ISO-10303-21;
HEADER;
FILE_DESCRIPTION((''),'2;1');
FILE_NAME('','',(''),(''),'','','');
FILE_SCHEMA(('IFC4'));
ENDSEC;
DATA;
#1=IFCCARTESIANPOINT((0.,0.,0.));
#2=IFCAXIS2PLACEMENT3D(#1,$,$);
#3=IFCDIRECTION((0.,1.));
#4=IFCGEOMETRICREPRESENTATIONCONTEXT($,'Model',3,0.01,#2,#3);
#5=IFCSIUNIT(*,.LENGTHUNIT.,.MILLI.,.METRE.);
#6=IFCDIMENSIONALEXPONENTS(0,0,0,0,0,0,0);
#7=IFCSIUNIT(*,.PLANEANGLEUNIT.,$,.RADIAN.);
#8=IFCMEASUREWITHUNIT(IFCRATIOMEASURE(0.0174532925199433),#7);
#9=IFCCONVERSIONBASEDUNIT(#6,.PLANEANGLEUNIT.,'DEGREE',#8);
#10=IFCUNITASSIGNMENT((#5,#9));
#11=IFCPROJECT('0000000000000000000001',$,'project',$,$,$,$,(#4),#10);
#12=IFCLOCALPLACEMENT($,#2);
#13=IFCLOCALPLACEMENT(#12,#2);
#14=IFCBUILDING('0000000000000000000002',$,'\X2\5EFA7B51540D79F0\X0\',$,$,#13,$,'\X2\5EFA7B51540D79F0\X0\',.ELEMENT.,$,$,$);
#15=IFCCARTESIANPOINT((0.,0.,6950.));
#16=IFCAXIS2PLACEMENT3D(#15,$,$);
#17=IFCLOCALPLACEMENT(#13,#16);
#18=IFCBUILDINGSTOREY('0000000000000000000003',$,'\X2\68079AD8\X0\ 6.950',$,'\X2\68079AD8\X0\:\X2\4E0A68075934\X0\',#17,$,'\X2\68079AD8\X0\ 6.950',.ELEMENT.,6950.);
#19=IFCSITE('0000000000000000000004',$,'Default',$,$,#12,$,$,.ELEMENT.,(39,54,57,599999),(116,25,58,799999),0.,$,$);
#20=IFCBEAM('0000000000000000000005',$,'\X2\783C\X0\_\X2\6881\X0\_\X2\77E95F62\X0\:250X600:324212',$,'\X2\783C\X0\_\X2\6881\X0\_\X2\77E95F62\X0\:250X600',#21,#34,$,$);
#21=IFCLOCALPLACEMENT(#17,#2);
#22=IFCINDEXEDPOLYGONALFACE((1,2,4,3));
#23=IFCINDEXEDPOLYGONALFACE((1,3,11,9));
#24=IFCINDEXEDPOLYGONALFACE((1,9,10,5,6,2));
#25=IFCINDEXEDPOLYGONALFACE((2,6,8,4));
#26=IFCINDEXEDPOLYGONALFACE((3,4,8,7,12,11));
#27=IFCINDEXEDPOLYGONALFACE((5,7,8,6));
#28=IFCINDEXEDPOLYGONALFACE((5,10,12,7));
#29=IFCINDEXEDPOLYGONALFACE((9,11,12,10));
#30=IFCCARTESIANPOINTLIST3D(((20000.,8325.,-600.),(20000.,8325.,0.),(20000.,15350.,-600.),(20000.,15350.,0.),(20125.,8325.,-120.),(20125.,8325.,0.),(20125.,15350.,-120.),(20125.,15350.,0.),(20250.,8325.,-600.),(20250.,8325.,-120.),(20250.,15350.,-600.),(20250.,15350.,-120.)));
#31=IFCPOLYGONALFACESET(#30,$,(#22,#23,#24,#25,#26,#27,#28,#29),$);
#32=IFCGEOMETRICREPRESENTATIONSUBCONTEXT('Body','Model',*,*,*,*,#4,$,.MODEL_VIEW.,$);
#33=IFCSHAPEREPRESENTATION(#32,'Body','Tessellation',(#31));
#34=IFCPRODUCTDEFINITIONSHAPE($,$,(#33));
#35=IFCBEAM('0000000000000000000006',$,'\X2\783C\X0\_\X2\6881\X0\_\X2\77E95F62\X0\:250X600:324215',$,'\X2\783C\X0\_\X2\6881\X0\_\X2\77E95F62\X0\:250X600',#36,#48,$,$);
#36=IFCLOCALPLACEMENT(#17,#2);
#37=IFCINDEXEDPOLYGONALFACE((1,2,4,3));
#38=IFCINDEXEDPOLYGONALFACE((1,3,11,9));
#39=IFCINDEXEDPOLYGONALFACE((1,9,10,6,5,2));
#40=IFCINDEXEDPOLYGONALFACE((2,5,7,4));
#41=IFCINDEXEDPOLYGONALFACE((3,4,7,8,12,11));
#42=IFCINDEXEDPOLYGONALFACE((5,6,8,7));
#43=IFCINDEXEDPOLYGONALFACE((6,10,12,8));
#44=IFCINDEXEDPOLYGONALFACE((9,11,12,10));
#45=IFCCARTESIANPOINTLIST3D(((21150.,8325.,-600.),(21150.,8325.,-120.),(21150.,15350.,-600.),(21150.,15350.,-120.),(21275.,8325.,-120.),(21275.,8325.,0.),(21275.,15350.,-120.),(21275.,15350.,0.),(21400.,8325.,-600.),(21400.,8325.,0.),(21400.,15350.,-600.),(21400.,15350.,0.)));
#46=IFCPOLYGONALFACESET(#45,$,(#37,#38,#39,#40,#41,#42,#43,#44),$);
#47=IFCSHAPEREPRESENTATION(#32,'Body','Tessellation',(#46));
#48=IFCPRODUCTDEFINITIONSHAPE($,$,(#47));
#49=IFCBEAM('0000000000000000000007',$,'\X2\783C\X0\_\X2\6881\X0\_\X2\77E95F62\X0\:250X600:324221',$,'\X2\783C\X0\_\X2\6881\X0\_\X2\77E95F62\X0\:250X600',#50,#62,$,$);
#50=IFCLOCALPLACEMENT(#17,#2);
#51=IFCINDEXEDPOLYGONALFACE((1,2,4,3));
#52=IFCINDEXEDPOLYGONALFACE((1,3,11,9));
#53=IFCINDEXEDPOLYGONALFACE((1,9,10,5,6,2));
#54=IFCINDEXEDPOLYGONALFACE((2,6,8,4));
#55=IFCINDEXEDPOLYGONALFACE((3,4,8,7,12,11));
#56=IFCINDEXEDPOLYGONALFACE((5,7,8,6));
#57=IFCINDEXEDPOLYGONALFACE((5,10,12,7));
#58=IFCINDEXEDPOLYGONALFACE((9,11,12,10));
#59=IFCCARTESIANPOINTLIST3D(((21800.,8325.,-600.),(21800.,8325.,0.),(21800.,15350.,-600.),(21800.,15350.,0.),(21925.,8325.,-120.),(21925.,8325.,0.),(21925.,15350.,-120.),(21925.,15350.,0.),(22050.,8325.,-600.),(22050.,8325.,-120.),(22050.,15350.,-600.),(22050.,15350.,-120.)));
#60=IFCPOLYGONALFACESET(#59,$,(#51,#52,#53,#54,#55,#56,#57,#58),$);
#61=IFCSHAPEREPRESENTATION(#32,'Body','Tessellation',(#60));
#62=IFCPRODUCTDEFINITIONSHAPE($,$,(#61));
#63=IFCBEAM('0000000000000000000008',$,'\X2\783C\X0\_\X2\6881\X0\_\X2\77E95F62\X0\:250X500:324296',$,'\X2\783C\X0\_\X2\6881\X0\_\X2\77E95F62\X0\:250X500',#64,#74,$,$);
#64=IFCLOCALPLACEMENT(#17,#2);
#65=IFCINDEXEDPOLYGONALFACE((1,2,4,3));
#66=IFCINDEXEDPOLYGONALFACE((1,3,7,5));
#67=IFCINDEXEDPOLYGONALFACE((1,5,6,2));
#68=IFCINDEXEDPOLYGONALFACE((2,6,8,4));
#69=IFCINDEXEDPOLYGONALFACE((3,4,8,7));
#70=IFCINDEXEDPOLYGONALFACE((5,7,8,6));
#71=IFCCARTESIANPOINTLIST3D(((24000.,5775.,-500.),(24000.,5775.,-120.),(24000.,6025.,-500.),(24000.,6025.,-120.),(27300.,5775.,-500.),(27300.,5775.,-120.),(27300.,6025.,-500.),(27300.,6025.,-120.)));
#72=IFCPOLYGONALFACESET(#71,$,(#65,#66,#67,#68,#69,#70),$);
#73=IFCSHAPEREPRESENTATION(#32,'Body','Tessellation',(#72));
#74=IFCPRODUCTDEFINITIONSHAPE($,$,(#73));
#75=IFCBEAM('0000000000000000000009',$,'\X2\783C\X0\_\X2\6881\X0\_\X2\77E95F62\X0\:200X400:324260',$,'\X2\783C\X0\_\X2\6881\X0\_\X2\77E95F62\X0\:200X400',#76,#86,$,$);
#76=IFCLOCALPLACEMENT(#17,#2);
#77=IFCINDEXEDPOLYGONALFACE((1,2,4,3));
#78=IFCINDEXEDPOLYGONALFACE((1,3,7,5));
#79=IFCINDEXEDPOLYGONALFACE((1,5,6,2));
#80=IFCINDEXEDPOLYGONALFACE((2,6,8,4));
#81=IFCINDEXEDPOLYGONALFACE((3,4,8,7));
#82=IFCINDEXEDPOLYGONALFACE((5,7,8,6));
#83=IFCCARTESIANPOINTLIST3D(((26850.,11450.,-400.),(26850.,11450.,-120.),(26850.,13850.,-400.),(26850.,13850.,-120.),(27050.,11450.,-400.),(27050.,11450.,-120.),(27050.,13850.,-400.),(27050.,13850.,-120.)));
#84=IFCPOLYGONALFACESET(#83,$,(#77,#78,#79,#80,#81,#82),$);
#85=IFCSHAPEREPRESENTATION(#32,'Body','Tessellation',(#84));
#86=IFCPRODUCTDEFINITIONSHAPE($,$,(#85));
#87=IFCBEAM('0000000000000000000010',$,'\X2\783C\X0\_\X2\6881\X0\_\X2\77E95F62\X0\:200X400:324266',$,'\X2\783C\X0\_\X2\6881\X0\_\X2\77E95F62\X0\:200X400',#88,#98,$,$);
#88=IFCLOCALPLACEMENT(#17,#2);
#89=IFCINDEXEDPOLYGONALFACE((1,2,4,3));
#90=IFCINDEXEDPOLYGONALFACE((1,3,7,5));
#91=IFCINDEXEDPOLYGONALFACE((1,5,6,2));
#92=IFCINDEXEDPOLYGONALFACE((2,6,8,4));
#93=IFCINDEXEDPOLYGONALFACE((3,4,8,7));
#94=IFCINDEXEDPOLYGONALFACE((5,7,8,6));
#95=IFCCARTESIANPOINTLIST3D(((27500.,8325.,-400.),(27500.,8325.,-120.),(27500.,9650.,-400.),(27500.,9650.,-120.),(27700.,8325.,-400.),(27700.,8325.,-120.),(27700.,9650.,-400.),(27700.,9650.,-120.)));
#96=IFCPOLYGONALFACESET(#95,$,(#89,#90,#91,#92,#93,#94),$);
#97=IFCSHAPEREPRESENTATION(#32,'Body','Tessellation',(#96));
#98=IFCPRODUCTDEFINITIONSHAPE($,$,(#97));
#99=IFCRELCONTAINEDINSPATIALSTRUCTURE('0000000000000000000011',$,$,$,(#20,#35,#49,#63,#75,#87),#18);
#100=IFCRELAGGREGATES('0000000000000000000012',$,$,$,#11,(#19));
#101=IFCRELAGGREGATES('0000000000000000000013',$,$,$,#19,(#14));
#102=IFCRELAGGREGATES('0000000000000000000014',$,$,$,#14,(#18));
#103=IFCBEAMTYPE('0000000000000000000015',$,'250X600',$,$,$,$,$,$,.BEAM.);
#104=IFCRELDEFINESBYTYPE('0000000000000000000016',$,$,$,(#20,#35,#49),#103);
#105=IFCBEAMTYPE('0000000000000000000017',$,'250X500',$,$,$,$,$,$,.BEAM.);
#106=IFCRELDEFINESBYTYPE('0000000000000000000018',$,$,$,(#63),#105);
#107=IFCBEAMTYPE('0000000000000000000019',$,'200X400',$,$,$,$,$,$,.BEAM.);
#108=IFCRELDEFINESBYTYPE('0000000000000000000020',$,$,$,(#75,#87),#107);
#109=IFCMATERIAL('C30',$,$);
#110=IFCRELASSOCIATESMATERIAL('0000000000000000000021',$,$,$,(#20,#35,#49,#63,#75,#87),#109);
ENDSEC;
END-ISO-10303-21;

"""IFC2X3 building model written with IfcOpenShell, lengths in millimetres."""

from ifc_helpers import new_model, entity, si_unit, converted_unit, direction, frame, frame_2d, origin, place, context, subcontext, project, spatial, polyline, rectangle, outline, extrude, material, type_object, element, save


model = new_model("IFC2X3")

# Units and contexts
model_context = context("Model", 3, precision=0.01, world=origin(), true_north=direction((0.0, 1.0)))
body_context = subcontext(model_context, "Body", "Model", "MODEL_VIEW")
ifc_project = project(units=[si_unit("LENGTHUNIT", "METRE", prefix="MILLI"), converted_unit("PLANEANGLEUNIT", "DEGREE", entity("IfcRatioMeasure", 0.0174532925199433), si_unit("PLANEANGLEUNIT", "RADIAN"), dimensions=[0, 0, 0, 0, 0, 0, 0])], contexts=[model_context])

# Site, building, storey
site_placement = place(None, origin())
site = spatial("IfcSite", under=ifc_project, at=site_placement, Name="Default", CompositionType="ELEMENT", RefLatitude=(39, 54, 57, 599999), RefLongitude=(116, 25, 58, 799999), RefElevation=0.0)
building_placement = place(site_placement, origin())
building = spatial("IfcBuilding", under=site, at=building_placement, Name="建筑名称", LongName="建筑名称", CompositionType="ELEMENT")
storey_placement = place(building_placement, frame((0.0, 0.0, 6950.0)))
storey = spatial("IfcBuildingStorey", under=building, at=storey_placement, Name="标高 6.950", ObjectType="标高:上标头", LongName="标高 6.950", CompositionType="ELEMENT", Elevation=6950.0)

# Beams
ifc_material_1 = material(Name="C30")
beam_type_1 = type_object("IfcBeamType", Name="250X600", PredefinedType="BEAM")
beam_1_placement = place(storey_placement, frame((20000.0, 8150.0, 0.0), z_axis=(0.0, 0.0, 1.0), x_axis=(0.0, 1.0, 0.0)))
element("IfcBeam", 1, at=beam_1_placement, inside=storey, type_object=beam_type_1, material=ifc_material_1, Name="砼_梁_矩形:250X600:324212", ObjectType="砼_梁_矩形:250X600", context=body_context, shape_type="SweptSolid", body=[
    extrude(outline(polyline([(-120.0, -125.0), (360.0, -125.0), (360.0, 125.0), (-240.0, 125.0), (-240.0, 0.0), (-120.0, 0.0), (-120.0, -125.0)])), frame((175.0, -125.0, -240.0), z_axis=(1.0, 0.0, 0.0), x_axis=(0.0, 0.0, -1.0)), (0.0, 0.0, 1.0), 7025.0),
])
beam_2_placement = place(storey_placement, frame((21400.0, 8150.0, 0.0), z_axis=(0.0, 0.0, 1.0), x_axis=(0.0, 1.0, 0.0)))
element("IfcBeam", 2, at=beam_2_placement, inside=storey, type_object=beam_type_1, material=ifc_material_1, Name="砼_梁_矩形:250X600:324215", ObjectType="砼_梁_矩形:250X600", context=body_context, shape_type="SweptSolid", body=[
    extrude(outline(polyline([(-240.0, -125.0), (360.0, -125.0), (360.0, 125.0), (-120.0, 125.0), (-120.0, 0.0), (-240.0, 0.0), (-240.0, -125.0)])), frame((175.0, 125.0, -240.0), z_axis=(1.0, 0.0, 0.0), x_axis=(0.0, 0.0, -1.0)), (0.0, 0.0, 1.0), 7025.0),
])
beam_3_placement = place(storey_placement, frame((21800.0, 8150.0, 0.0), z_axis=(0.0, 0.0, 1.0), x_axis=(0.0, 1.0, 0.0)))
element("IfcBeam", 3, at=beam_3_placement, inside=storey, type_object=beam_type_1, material=ifc_material_1, Name="砼_梁_矩形:250X600:324221", ObjectType="砼_梁_矩形:250X600", context=body_context, shape_type="SweptSolid", body=[
    extrude(outline(polyline([(-120.0, -125.0), (360.0, -125.0), (360.0, 125.0), (-240.0, 125.0), (-240.0, 0.0), (-120.0, 0.0), (-120.0, -125.0)])), frame((175.0, -125.0, -240.0), z_axis=(1.0, 0.0, 0.0), x_axis=(0.0, 0.0, -1.0)), (0.0, 0.0, 1.0), 7025.0),
])
beam_type_2 = type_object("IfcBeamType", Name="250X500", PredefinedType="BEAM")
beam_4_placement = place(storey_placement, frame((24000.0, 5900.0, 0.0)))
element("IfcBeam", 4, at=beam_4_placement, inside=storey, type_object=beam_type_2, material=ifc_material_1, Name="砼_梁_矩形:250X500:324296", ObjectType="砼_梁_矩形:250X500", context=body_context, shape_type="SweptSolid", body=[
    extrude(rectangle(XDim=380.0, YDim=250.0, at=frame_2d((0.0, 0.0), x_axis=(1.0, 0.0))), frame((0.0, 0.0, -310.0), z_axis=(1.0, 0.0, 0.0), x_axis=(0.0, 0.0, -1.0)), (0.0, 0.0, 1.0), 3300.0),
])
beam_type_3 = type_object("IfcBeamType", Name="200X400", PredefinedType="BEAM")
beam_5_placement = place(storey_placement, frame((27050.0, 11450.0, 0.0), z_axis=(0.0, 0.0, 1.0), x_axis=(0.0, 1.0, 0.0)))
element("IfcBeam", 5, at=beam_5_placement, inside=storey, type_object=beam_type_3, material=ifc_material_1, Name="砼_梁_矩形:200X400:324260", ObjectType="砼_梁_矩形:200X400", context=body_context, shape_type="SweptSolid", body=[
    extrude(rectangle(XDim=280.0, YDim=200.0, at=frame_2d((0.0, 0.0), x_axis=(1.0, 0.0))), frame((0.0, 100.0, -260.0), z_axis=(1.0, 0.0, 0.0), x_axis=(0.0, 0.0, -1.0)), (0.0, 0.0, 1.0), 2400.0),
])
beam_6_placement = place(storey_placement, frame((27700.0, 8150.0, 0.0), z_axis=(0.0, 0.0, 1.0), x_axis=(0.0, 1.0, 0.0)))
element("IfcBeam", 6, at=beam_6_placement, inside=storey, type_object=beam_type_3, material=ifc_material_1, Name="砼_梁_矩形:200X400:324266", ObjectType="砼_梁_矩形:200X400", context=body_context, shape_type="SweptSolid", body=[
    extrude(rectangle(XDim=280.0, YDim=200.0, at=frame_2d((0.0, 0.0), x_axis=(1.0, 0.0))), frame((175.0, 100.0, -260.0), z_axis=(1.0, 0.0, 0.0), x_axis=(0.0, 0.0, -1.0)), (0.0, 0.0, 1.0), 1325.0),
])

save(model, "model.ifc")
